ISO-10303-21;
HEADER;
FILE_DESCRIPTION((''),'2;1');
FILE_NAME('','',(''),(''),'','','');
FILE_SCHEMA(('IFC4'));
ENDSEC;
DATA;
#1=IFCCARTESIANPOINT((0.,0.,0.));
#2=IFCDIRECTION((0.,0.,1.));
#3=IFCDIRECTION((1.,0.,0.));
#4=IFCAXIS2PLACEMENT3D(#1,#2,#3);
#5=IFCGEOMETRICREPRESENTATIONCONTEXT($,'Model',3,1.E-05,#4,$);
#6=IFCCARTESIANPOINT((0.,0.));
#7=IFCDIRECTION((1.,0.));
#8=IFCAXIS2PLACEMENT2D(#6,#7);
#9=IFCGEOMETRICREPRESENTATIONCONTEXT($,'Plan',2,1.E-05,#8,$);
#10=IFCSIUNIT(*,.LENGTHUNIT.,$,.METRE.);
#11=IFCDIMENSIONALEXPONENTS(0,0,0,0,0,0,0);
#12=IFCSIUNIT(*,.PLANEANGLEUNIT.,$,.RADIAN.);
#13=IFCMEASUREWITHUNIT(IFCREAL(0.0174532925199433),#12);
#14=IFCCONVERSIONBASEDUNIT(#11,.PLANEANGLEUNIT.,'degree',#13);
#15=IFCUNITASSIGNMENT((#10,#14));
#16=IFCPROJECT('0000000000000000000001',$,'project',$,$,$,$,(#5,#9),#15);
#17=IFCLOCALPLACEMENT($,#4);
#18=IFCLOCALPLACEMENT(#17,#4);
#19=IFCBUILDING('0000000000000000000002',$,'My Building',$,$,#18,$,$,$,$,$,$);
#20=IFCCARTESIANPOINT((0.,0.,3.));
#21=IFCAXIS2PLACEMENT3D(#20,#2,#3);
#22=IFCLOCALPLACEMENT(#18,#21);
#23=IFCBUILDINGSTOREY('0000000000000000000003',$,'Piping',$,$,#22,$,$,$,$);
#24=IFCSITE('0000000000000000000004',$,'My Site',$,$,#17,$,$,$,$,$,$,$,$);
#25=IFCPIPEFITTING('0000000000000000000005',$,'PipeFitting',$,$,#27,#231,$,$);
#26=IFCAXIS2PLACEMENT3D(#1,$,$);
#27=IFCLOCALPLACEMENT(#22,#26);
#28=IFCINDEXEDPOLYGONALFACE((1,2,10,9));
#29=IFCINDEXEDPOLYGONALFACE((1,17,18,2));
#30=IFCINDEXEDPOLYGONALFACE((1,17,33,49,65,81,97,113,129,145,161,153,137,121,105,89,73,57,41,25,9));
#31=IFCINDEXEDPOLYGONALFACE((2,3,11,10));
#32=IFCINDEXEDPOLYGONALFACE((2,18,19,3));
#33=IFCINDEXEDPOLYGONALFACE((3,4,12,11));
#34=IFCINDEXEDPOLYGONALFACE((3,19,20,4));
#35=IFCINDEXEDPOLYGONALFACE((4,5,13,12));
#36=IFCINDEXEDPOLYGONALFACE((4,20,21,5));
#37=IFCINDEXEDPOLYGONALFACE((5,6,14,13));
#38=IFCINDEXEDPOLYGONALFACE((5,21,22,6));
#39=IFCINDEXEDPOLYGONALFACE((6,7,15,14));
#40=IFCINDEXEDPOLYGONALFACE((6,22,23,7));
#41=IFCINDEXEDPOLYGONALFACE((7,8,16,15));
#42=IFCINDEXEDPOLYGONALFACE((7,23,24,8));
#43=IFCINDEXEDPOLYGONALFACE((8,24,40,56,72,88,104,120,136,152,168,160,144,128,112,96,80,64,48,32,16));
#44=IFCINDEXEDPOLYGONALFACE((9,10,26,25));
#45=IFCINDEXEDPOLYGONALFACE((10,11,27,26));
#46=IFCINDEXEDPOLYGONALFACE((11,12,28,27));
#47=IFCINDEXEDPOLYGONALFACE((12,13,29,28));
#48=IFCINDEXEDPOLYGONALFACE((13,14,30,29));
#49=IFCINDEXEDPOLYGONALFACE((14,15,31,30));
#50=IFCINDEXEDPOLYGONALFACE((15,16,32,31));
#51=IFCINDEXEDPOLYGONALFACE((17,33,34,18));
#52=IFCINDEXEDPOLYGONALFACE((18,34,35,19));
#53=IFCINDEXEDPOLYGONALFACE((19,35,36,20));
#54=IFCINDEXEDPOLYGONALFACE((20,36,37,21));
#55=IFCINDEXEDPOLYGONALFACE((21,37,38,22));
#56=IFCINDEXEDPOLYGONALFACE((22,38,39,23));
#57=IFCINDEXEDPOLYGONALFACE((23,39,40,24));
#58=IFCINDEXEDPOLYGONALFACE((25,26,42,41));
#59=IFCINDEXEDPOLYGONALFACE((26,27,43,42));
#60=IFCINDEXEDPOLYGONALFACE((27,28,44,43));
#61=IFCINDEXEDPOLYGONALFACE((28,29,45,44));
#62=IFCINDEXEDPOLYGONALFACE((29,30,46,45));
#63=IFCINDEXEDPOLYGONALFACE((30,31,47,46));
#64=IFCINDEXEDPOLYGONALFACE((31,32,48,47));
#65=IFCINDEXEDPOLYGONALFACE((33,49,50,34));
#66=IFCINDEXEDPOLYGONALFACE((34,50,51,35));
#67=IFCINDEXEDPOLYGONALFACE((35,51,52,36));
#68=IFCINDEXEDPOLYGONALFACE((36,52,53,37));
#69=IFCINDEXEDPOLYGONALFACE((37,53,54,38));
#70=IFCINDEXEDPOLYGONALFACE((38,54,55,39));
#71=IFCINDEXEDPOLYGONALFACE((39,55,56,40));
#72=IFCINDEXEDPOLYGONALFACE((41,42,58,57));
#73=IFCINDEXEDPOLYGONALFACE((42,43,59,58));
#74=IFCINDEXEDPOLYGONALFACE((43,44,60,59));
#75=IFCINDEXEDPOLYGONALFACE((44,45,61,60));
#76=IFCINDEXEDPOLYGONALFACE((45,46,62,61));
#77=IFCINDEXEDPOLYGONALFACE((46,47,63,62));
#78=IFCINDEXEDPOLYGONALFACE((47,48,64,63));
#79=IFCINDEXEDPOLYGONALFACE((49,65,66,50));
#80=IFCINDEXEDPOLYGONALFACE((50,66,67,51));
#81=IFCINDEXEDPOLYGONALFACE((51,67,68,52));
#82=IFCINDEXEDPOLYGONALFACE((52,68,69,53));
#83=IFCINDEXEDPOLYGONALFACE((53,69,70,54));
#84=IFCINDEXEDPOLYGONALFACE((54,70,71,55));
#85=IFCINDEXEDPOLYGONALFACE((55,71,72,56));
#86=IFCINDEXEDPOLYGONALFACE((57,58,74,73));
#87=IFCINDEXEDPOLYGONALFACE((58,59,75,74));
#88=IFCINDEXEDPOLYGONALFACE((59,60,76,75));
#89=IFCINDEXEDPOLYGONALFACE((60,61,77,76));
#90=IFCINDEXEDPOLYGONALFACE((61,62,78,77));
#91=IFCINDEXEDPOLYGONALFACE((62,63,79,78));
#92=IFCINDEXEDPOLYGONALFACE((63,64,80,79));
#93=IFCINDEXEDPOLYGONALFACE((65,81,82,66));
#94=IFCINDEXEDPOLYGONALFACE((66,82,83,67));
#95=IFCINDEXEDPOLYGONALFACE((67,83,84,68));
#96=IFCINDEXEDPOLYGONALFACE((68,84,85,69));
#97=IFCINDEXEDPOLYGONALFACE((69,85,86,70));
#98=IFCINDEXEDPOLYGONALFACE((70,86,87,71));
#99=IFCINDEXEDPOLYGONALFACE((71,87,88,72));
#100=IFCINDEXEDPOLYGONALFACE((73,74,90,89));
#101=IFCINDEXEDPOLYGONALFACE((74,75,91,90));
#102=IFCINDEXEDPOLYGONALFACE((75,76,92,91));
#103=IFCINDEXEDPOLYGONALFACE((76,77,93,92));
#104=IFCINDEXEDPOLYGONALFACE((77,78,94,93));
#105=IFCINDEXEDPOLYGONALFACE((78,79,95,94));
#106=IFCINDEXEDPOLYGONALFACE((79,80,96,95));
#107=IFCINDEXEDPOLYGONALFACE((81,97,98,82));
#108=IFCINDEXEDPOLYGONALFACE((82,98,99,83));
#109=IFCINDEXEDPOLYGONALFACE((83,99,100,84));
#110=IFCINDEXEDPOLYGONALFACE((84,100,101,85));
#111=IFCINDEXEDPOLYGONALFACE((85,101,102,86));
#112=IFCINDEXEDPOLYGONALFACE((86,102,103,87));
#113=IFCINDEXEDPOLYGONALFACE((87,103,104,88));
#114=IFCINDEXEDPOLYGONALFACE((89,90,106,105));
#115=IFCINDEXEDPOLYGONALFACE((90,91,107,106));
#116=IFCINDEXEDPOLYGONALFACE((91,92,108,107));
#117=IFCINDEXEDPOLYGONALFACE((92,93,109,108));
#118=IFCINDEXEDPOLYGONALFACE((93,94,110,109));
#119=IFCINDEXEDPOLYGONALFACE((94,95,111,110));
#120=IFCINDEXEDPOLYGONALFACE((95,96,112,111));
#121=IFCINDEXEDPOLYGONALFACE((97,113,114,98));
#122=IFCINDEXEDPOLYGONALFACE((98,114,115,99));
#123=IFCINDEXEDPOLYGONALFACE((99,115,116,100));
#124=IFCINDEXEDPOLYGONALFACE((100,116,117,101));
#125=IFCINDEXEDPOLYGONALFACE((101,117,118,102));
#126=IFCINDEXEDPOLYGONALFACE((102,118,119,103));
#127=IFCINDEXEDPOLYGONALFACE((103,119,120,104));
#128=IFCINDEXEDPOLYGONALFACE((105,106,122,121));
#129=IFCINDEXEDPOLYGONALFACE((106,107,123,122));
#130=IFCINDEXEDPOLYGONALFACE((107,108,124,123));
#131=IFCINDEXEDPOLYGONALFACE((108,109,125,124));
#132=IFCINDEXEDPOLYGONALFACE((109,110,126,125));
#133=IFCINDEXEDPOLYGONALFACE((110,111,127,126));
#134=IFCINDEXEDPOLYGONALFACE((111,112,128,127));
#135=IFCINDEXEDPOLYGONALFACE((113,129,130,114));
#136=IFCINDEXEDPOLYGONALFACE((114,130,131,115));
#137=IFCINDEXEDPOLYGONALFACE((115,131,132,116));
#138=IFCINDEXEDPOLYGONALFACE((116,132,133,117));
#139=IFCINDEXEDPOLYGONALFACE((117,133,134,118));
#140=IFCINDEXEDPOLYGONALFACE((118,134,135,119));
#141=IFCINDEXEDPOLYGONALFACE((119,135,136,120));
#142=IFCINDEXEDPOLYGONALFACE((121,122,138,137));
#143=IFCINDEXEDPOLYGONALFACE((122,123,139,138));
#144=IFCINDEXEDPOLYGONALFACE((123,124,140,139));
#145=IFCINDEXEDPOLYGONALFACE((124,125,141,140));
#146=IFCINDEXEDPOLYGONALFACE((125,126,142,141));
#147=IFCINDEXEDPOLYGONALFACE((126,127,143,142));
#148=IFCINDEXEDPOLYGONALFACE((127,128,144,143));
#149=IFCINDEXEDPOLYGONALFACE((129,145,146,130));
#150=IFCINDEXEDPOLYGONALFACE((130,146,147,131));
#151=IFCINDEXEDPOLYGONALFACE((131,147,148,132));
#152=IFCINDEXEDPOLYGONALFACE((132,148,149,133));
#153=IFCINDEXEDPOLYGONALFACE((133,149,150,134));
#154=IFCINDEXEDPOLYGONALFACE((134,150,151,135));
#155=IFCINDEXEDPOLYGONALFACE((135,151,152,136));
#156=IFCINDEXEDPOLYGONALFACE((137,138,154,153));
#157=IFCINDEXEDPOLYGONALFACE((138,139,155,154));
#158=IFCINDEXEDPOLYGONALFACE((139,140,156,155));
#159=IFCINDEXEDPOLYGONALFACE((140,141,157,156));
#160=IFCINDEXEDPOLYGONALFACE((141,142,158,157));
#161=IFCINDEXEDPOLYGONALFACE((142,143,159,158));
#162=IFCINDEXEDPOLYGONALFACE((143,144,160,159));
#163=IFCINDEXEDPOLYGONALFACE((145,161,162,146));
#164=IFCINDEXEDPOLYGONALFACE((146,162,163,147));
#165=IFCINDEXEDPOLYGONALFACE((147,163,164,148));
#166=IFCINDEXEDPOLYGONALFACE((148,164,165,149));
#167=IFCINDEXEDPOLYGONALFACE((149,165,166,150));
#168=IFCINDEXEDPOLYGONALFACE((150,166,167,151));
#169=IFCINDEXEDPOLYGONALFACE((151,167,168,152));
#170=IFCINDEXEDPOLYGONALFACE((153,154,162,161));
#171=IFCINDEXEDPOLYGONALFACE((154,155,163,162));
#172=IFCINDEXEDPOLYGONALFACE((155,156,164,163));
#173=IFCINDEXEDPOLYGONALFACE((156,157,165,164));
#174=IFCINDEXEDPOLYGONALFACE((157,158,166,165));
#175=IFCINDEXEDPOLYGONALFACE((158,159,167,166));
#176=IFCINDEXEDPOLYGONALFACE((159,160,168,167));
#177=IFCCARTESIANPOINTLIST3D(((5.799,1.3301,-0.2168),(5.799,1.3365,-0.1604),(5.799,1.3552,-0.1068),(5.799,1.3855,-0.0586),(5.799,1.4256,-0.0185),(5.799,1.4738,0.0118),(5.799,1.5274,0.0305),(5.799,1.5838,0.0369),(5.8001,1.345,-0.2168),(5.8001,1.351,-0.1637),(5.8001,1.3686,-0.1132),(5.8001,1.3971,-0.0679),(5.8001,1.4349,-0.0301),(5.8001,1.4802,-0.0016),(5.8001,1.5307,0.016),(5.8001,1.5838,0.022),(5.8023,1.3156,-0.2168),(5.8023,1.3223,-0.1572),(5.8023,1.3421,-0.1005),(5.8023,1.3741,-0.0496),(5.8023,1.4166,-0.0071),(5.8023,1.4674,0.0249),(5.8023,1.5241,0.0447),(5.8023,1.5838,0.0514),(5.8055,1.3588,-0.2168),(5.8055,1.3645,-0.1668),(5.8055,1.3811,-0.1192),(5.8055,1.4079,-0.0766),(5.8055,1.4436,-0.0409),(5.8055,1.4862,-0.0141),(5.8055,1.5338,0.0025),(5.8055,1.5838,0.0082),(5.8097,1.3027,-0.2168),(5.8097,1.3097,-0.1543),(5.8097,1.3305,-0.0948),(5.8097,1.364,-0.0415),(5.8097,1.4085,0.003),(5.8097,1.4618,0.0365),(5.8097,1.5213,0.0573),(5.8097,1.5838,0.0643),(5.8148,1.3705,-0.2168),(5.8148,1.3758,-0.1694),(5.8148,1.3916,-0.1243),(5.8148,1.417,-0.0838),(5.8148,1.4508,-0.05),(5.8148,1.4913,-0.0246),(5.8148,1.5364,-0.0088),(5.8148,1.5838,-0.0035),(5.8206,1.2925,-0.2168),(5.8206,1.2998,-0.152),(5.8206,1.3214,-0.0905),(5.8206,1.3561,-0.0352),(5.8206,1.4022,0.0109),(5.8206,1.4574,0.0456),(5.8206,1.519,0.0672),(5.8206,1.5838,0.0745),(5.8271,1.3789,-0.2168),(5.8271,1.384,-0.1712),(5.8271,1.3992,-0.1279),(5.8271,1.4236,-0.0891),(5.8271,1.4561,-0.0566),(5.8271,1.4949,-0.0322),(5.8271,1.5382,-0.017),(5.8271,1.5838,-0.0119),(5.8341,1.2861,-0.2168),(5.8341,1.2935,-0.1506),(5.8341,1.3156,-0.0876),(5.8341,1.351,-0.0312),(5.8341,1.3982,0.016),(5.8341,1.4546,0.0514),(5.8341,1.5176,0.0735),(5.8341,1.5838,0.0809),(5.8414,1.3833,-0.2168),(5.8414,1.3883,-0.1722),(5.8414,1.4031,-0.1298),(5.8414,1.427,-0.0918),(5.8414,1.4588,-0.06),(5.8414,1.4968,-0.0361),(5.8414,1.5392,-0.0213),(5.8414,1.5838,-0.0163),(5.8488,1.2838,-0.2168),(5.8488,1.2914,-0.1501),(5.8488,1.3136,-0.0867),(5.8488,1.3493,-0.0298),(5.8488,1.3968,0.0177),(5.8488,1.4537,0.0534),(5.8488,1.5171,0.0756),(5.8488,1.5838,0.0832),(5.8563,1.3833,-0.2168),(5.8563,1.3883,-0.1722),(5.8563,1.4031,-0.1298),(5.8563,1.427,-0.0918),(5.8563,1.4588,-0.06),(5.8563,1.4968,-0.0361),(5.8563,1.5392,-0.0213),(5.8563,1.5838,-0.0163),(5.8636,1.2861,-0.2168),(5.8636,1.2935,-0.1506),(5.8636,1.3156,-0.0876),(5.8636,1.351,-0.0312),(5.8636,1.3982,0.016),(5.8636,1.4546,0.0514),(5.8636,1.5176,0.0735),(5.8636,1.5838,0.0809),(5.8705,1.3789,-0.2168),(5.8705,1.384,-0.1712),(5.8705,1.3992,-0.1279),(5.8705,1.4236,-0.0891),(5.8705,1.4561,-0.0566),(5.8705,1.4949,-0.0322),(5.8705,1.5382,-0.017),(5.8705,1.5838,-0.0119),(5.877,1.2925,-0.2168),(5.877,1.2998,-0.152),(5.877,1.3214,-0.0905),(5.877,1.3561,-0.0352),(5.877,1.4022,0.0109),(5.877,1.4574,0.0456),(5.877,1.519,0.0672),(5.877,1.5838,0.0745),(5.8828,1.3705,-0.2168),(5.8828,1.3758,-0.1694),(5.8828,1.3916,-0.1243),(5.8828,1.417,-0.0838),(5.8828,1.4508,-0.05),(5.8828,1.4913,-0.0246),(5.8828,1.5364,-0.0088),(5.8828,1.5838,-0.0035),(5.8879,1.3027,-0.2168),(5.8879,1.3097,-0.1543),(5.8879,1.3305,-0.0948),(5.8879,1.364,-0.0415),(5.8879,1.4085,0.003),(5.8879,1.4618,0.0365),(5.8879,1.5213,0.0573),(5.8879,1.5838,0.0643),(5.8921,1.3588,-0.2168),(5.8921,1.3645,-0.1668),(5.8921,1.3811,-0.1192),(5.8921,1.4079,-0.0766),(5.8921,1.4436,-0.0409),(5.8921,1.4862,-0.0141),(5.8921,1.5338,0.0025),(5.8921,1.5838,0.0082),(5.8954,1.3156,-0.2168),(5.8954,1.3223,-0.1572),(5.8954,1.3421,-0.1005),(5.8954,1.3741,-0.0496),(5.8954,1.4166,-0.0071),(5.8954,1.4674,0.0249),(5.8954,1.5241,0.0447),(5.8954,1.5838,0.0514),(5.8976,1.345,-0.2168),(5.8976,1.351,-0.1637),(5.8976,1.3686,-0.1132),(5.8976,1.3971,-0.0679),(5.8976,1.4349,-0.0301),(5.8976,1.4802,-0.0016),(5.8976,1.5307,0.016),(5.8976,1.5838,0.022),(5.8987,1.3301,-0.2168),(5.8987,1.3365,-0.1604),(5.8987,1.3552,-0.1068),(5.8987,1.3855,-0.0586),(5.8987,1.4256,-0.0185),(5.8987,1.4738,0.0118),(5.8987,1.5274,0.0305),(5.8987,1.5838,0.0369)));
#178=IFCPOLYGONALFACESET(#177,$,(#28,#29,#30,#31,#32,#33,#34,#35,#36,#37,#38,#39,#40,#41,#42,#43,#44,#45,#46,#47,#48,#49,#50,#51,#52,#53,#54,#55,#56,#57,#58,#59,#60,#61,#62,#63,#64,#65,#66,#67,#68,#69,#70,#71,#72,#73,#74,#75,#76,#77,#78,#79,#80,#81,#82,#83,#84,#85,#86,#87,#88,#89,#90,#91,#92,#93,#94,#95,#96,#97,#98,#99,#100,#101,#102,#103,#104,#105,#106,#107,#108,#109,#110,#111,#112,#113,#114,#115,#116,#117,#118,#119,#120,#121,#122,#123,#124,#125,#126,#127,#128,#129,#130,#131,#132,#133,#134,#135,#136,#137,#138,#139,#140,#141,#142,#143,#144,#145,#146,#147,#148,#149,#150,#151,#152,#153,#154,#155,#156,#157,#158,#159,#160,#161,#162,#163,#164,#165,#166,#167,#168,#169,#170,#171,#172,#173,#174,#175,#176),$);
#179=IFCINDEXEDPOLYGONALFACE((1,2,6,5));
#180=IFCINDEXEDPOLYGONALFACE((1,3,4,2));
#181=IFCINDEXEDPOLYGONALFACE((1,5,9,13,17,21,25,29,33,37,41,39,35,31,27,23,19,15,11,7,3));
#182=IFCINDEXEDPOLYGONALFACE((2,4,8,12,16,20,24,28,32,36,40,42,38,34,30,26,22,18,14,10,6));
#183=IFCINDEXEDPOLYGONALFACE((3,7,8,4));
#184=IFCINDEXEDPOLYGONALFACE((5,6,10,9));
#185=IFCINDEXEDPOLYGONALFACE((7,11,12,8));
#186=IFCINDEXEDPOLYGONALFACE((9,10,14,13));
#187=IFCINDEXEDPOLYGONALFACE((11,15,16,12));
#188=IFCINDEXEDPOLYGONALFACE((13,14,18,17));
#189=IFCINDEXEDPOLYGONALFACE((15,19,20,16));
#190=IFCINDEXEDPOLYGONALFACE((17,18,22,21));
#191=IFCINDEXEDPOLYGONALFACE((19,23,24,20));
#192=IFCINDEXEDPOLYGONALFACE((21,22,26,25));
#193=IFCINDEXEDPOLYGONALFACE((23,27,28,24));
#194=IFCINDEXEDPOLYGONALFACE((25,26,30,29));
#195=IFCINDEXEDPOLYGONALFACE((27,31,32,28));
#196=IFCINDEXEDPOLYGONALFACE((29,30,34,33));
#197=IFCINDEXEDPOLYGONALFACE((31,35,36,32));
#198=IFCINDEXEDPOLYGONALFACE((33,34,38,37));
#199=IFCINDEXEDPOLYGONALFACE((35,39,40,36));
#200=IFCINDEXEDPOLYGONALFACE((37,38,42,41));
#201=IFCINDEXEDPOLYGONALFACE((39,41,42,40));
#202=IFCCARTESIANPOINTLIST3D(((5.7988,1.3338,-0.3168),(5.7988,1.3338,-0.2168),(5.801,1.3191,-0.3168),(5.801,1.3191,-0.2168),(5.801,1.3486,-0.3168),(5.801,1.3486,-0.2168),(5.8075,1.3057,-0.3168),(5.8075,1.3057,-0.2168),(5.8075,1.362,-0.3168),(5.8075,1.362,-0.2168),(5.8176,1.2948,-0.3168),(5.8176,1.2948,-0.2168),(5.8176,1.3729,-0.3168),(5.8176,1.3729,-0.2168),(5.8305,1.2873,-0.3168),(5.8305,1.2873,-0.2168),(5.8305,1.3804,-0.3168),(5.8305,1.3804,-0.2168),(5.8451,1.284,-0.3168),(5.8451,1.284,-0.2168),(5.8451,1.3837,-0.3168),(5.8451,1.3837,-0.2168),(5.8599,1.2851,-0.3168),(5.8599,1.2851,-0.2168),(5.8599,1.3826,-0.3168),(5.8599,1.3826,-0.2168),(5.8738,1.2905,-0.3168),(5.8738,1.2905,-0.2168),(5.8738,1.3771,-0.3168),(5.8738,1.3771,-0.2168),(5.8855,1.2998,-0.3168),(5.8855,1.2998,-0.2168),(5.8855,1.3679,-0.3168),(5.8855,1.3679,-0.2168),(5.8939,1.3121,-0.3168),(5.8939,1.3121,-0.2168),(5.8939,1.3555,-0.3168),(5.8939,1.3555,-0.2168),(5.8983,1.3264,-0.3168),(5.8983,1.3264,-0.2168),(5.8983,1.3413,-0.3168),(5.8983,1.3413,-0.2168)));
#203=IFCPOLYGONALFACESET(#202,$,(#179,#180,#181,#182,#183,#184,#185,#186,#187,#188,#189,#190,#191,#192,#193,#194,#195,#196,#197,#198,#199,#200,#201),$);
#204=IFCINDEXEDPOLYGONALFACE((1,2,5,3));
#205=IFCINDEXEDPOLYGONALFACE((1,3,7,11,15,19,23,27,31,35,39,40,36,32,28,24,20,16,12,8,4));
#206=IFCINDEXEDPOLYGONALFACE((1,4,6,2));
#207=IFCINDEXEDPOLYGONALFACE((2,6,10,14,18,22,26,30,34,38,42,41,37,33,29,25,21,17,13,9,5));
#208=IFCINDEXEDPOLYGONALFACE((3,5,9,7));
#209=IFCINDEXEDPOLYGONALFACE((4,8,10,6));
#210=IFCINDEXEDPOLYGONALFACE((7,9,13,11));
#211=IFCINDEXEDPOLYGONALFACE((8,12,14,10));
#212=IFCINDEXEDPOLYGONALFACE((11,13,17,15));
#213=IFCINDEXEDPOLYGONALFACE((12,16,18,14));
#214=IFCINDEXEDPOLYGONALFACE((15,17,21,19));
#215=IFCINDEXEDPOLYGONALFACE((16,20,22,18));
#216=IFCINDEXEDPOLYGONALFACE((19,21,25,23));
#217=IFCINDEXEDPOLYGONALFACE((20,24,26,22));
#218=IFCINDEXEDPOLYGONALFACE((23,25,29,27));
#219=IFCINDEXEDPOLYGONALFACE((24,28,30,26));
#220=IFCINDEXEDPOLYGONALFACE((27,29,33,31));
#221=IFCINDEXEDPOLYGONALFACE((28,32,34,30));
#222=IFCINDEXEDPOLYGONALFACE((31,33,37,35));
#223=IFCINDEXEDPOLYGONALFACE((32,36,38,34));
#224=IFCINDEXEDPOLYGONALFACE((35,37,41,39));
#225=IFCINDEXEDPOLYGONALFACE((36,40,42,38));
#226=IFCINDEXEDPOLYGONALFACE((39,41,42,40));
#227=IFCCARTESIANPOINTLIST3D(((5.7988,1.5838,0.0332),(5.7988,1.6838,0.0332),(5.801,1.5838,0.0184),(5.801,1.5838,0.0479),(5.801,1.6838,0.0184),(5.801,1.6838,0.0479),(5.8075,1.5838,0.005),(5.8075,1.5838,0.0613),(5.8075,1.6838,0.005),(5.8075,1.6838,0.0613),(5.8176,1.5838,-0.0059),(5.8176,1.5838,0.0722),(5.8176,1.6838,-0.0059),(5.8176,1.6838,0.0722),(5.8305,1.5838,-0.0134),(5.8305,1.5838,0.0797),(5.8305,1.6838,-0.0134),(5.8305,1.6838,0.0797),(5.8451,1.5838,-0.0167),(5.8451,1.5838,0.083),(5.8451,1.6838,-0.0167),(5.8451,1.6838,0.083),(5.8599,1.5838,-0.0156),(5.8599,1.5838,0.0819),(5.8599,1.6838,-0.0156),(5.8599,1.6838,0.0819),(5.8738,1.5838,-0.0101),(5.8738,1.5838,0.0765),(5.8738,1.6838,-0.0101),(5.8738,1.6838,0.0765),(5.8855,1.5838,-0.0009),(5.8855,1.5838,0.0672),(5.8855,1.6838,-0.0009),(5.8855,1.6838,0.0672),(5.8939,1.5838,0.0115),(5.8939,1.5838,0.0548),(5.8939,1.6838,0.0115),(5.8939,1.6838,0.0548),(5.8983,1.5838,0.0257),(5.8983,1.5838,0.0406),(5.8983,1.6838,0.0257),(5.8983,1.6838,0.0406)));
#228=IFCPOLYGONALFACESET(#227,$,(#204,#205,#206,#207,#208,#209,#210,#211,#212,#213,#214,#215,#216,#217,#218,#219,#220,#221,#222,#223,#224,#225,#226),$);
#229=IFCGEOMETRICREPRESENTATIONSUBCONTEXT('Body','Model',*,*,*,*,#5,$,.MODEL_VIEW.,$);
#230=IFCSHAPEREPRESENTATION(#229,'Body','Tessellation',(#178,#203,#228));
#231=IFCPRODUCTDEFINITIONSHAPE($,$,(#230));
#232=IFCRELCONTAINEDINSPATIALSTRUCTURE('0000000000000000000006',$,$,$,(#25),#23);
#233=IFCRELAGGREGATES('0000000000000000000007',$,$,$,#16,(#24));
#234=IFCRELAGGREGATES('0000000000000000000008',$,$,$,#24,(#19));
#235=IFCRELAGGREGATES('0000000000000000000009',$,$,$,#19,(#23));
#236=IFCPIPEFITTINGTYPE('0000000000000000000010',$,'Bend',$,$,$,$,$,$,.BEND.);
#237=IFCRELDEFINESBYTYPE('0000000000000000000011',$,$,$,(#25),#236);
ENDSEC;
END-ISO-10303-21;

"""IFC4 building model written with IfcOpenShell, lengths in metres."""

from ifc_helpers import new_model, entity, si_unit, converted_unit, frame, origin_with_axes, origin_2d_with_axis, place, context, subcontext, project, spatial, circle, extrude, source, transform, mapped, type_object, type_shapes, element, save


model = new_model("IFC4")

# Units and contexts
model_context = context("Model", 3, precision=1e-05, world=origin_with_axes())
plan_context = context("Plan", 2, precision=1e-05, world=origin_2d_with_axis())
body_context = subcontext(model_context, "Body", "Model", "MODEL_VIEW")
ifc_project = project(units=[si_unit("LENGTHUNIT", "METRE"), converted_unit("PLANEANGLEUNIT", "degree", entity("IfcReal", 0.0174532925199433), si_unit("PLANEANGLEUNIT", "RADIAN"), dimensions=[0, 0, 0, 0, 0, 0, 0])], contexts=[model_context, plan_context])

# Site, building, storey
site_placement = place(None, origin_with_axes())
site = spatial("IfcSite", under=ifc_project, at=site_placement, Name="My Site")
building_placement = place(site_placement, origin_with_axes())
building = spatial("IfcBuilding", under=site, at=building_placement, Name="My Building")
storey_placement = place(building_placement, frame((0.0, 0.0, 3.0), z_axis=(0.0, 0.0, 1.0), x_axis=(1.0, 0.0, 0.0)))
storey = spatial("IfcBuildingStorey", under=building, at=storey_placement, Name="Piping")

# Pipe fitting
pipe_fitting_type = type_object("IfcPipeFittingType", Name="Bend", PredefinedType="BEND")
shared_shape = source(origin_with_axes(), body_context, "Body", "SolidModel", [
    entity("IfcSweptDiskSolid", entity("IfcIndexedPolyCurve", entity("IfcCartesianPointList3D", [[0.0, 0.0, -0.1], [0.0, 0.0732, -0.2768], [0.0, 0.25, -0.35]]), [entity("IfcArcIndex", [1, 2, 3])]), 0.05),
    extrude(circle(Radius=0.05), origin_with_axes(), (0.0, 0.0, -1.0), 0.1),
    extrude(circle(Radius=0.05), frame((0.0, 0.25, -0.35), z_axis=(0.0, 1.0, 0.0), x_axis=(1.0, 0.0, 0.0)), (0.0, 0.0, 1.0), 0.1),
])
type_shapes(pipe_fitting_type, [shared_shape])
for number, where, z_axis, x_axis, name in (
    (1, (5.8488, 1.3338, -0.3168), (0.0, 0.0, -1.0), (-1.0, 0.0, 0.0), "PipeFitting"),
):
    element("IfcPipeFitting", number, at=place(storey_placement, frame(where, z_axis=z_axis, x_axis=x_axis)), inside=storey, type_object=pipe_fitting_type, Name=name, context=body_context, shape_type="MappedRepresentation", body=[
        mapped(shared_shape, transform((0.0, 0.0, 0.0), x_axis=(1.0, 0.0, 0.0), y_axis=(0.0, 1.0, 0.0), z_axis=(0.0, 0.0, 1.0), scale=1.0)),
    ])

save(model, "model.ifc")
